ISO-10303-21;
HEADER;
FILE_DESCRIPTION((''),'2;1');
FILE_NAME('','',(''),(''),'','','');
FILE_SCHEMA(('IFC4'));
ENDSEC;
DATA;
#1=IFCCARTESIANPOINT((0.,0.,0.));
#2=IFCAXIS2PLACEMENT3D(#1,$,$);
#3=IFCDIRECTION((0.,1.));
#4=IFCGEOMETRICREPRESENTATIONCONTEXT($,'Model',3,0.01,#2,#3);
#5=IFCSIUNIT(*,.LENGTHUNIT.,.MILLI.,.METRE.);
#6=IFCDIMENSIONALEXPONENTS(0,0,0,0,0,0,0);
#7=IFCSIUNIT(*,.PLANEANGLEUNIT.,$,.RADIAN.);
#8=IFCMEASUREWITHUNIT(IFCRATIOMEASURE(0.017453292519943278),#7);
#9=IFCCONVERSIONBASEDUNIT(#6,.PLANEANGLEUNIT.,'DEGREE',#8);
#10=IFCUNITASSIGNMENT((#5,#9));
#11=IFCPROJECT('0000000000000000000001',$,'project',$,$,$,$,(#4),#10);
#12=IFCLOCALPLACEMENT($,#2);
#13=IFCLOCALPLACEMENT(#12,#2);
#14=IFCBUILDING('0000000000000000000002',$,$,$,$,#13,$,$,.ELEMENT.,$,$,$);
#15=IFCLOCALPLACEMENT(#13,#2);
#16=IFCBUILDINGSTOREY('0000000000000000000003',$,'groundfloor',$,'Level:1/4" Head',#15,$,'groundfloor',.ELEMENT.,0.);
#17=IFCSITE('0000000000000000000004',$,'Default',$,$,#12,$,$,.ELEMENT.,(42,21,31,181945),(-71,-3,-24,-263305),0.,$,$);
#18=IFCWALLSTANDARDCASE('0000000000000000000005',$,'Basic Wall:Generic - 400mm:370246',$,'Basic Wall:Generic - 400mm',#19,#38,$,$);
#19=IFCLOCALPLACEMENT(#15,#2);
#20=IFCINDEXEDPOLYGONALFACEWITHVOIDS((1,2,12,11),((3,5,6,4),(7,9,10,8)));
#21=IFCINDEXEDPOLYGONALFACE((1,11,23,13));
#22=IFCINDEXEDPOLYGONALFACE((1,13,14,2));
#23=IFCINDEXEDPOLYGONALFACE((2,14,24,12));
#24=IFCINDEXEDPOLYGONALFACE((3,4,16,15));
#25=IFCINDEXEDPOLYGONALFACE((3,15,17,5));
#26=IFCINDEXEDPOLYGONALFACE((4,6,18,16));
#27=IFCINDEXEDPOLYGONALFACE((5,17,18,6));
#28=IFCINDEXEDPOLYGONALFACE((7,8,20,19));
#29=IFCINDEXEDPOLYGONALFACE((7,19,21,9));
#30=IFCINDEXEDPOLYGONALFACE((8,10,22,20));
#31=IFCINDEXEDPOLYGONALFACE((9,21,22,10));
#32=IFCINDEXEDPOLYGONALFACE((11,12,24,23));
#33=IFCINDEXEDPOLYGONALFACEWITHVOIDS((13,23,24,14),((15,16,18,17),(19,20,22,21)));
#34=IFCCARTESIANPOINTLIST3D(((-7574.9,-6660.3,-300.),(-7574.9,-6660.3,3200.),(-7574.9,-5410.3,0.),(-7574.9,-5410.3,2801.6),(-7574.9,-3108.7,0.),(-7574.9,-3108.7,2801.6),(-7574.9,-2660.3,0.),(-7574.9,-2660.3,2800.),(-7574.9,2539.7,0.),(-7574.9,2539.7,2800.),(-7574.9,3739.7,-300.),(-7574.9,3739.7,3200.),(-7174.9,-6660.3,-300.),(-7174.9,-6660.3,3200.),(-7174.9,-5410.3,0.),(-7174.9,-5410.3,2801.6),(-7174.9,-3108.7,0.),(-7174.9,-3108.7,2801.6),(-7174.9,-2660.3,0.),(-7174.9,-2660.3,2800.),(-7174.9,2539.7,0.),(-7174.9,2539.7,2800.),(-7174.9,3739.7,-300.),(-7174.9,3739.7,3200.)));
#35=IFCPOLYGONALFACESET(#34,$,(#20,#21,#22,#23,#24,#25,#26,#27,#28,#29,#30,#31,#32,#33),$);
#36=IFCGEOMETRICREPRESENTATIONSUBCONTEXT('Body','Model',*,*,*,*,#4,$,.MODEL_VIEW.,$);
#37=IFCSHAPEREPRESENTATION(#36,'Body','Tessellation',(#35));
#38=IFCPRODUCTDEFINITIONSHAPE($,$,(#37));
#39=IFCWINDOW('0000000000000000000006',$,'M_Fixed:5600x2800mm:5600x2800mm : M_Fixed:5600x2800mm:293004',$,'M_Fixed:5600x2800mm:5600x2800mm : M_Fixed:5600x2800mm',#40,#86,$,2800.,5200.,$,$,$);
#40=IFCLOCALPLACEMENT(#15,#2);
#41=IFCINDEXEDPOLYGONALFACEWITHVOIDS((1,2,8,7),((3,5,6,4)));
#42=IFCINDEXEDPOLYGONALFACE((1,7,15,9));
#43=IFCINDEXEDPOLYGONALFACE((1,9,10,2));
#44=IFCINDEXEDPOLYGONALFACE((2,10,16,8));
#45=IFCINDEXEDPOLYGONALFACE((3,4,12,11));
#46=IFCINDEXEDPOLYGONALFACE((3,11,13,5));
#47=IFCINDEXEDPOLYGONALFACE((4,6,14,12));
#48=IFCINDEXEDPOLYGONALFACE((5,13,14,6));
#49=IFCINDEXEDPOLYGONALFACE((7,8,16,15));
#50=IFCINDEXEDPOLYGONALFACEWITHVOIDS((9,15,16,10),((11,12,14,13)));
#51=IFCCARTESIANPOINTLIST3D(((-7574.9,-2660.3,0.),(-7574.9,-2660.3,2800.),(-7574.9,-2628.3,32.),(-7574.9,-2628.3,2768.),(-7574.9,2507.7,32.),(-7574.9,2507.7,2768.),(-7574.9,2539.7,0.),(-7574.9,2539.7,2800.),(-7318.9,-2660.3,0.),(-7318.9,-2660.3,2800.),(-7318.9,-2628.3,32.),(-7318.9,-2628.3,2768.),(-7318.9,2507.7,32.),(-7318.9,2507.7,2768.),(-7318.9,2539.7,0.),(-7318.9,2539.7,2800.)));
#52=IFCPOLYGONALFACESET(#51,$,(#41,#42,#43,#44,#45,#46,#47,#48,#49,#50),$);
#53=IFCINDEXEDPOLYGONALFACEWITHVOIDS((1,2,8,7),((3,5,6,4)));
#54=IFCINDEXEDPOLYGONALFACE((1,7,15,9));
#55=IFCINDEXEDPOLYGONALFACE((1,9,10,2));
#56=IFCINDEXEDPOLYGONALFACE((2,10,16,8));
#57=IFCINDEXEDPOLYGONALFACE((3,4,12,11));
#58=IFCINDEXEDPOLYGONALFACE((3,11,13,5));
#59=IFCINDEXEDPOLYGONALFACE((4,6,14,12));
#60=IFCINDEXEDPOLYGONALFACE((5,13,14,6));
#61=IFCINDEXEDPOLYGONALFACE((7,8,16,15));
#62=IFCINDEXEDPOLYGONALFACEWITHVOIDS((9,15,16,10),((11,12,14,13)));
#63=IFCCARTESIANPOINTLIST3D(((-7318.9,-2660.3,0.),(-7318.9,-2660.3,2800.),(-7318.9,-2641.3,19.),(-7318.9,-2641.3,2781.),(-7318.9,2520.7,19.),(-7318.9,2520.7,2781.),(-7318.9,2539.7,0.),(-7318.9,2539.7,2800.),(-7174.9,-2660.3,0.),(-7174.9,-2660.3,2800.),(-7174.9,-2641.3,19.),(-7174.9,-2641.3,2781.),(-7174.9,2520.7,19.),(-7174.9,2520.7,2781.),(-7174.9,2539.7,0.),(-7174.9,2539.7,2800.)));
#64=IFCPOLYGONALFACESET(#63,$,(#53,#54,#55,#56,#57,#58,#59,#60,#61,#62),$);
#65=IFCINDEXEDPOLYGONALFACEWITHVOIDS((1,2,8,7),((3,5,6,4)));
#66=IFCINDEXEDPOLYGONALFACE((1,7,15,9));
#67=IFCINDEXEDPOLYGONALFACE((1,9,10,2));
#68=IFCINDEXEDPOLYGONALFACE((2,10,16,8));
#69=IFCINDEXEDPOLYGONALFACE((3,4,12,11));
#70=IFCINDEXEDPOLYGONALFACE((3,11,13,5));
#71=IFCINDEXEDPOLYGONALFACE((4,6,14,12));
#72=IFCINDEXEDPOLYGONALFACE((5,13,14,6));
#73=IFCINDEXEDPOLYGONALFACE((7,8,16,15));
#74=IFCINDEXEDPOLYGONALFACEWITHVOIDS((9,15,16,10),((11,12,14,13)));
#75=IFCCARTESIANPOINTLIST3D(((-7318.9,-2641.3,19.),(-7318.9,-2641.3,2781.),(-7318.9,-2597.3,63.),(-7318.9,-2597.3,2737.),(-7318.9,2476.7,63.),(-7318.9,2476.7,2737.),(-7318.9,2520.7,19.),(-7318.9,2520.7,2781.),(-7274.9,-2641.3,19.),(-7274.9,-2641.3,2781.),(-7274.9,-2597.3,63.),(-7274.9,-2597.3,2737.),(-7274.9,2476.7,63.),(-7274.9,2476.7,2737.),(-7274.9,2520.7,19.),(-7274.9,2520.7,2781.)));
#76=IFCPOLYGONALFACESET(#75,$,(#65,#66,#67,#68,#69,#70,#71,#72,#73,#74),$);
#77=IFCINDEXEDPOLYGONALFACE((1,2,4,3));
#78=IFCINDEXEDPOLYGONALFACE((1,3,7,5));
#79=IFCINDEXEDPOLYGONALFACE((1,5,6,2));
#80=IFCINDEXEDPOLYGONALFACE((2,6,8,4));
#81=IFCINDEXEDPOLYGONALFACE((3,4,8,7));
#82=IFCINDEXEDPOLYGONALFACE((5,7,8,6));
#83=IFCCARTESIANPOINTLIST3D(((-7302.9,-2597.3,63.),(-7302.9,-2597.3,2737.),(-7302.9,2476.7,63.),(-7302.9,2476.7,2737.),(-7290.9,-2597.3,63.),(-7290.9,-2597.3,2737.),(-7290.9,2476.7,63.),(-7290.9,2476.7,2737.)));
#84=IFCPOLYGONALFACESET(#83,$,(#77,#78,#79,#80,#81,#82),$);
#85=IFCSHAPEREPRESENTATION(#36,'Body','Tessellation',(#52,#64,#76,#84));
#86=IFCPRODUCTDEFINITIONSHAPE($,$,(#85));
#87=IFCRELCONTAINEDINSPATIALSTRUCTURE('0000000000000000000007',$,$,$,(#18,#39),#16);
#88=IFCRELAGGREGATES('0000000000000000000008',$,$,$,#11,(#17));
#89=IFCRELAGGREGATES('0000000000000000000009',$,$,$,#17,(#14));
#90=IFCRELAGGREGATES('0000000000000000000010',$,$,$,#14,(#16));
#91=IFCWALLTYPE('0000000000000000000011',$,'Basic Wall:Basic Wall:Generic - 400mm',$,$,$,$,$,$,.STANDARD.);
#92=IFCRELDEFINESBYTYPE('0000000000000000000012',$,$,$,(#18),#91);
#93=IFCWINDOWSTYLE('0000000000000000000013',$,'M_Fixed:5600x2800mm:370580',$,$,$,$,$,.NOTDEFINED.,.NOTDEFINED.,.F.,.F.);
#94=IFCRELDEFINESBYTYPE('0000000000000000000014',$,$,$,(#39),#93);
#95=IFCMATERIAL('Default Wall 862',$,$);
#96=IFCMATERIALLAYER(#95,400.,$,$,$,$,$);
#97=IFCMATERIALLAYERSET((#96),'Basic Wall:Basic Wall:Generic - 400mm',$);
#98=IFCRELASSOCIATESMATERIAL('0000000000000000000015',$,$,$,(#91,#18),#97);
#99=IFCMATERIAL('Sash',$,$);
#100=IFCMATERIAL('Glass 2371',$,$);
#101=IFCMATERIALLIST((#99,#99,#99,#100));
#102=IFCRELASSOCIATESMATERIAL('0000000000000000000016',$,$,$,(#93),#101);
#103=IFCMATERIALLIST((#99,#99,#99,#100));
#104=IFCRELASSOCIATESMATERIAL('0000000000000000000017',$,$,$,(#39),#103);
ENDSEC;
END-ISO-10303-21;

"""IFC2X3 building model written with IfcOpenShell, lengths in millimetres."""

from ifc_helpers import new_model, entity, si_unit, converted_unit, direction, frame, frame_2d, origin, origin_2d_with_axis, place, context, subcontext, project, spatial, polyline, rectangle, outline, extrude, source, transform, mapped, material, material_list, layer, layer_set, layer_usage, type_object, type_shapes, element, fill, save


model = new_model("IFC2X3")

# Units and contexts
model_context = context("Model", 3, precision=0.01, world=origin(), true_north=direction((0.0, 1.0)))
body_context = subcontext(model_context, "Body", "Model", "MODEL_VIEW")
ifc_project = project(units=[si_unit("LENGTHUNIT", "METRE", prefix="MILLI"), converted_unit("PLANEANGLEUNIT", "DEGREE", entity("IfcRatioMeasure", 0.017453292519943278), si_unit("PLANEANGLEUNIT", "RADIAN"), dimensions=[0, 0, 0, 0, 0, 0, 0])], contexts=[model_context])

# Site, building, storey
site_placement = place(None, origin())
site = spatial("IfcSite", under=ifc_project, at=site_placement, Name="Default", CompositionType="ELEMENT", RefLatitude=(42, 21, 31, 181945), RefLongitude=(-71, -3, -24, -263305), RefElevation=0.0)
building_placement = place(site_placement, origin())
building = spatial("IfcBuilding", under=site, at=building_placement, CompositionType="ELEMENT")
storey_placement = place(building_placement, origin())
storey = spatial("IfcBuildingStorey", under=building, at=storey_placement, Name="groundfloor", ObjectType="Level:1/4\" Head", LongName="groundfloor", CompositionType="ELEMENT", Elevation=0.0)

# Wall, openings, window
ifc_material_1 = material(Name="Default Wall 862")
ifc_layer_1 = layer(ifc_material_1, 400.0)
ifc_layer_set_1 = layer_set([ifc_layer_1], Name="Basic Wall:Basic Wall:Generic - 400mm")
wall_type_1 = type_object("IfcWallType", Name="Basic Wall:Basic Wall:Generic - 400mm", PredefinedType="STANDARD", material=ifc_layer_set_1)
ifc_material_2 = material(Name="Sash")
ifc_material_3 = material(Name="Glass 2371")
ifc_layer_usage_1 = layer_usage(ifc_layer_set_1, "AXIS2", "NEGATIVE", 200.0)
wall_1_placement = place(storey_placement, frame((-7374.9, 3739.7, -300.0), z_axis=(0.0, 0.0, 1.0), x_axis=(0.0, -1.0, 0.0)))
wall_1 = element("IfcWallStandardCase", 1, at=wall_1_placement, inside=storey, type_object=wall_type_1, material=ifc_layer_usage_1, Name="Basic Wall:Generic - 400mm:370246", ObjectType="Basic Wall:Generic - 400mm", context=body_context, shape_type="SweptSolid", body=[
    extrude(rectangle(XDim=10400.0, YDim=400.0, at=frame_2d((5200.0, 0.0), x_axis=(-1.0, 0.0))), origin(), (0.0, 0.0, 1.0), 3500.0),
])
opening_1_placement = place(wall_1_placement, origin())
element("IfcOpeningElement", 2, at=opening_1_placement, cuts=wall_1, ObjectType="Opening", context=body_context, shape_type="SweptSolid", body=[
    extrude(rectangle(XDim=2500.0, YDim=1000.0, at=origin_2d_with_axis()), frame((1700.0, -200.0, 4750.0), z_axis=(0.0, 1.0, 0.0), x_axis=(0.0, 0.0, -1.0)), (0.0, 0.0, 1.0), 400.0),
])
opening_2_placement = place(wall_1_placement, origin())
element("IfcOpeningElement", 3, at=opening_2_placement, cuts=wall_1, ObjectType="Opening", context=body_context, shape_type="SweptSolid", body=[
    extrude(rectangle(XDim=2500.0, YDim=1000.0, at=origin_2d_with_axis()), frame((3100.0, -200.0, 4750.0), z_axis=(0.0, 1.0, 0.0), x_axis=(0.0, 0.0, -1.0)), (0.0, 0.0, 1.0), 400.0),
])
opening_3_placement = place(wall_1_placement, origin())
element("IfcOpeningElement", 4, at=opening_3_placement, cuts=wall_1, ObjectType="Opening", context=body_context, shape_type="SweptSolid", body=[
    extrude(rectangle(XDim=2500.0, YDim=1000.0, at=origin_2d_with_axis()), frame((4500.0, -200.0, 4750.0), z_axis=(0.0, 1.0, 0.0), x_axis=(0.0, 0.0, -1.0)), (0.0, 0.0, 1.0), 400.0),
])
opening_4_placement = place(wall_1_placement, origin())
element("IfcOpeningElement", 5, at=opening_4_placement, cuts=wall_1, ObjectType="Opening", context=body_context, shape_type="SweptSolid", body=[
    extrude(rectangle(XDim=2500.0, YDim=1000.0, at=origin_2d_with_axis()), frame((5900.0, -200.0, 4750.0), z_axis=(0.0, 1.0, 0.0), x_axis=(0.0, 0.0, -1.0)), (0.0, 0.0, 1.0), 400.0),
])
opening_5_placement = place(wall_1_placement, origin())
element("IfcOpeningElement", 6, at=opening_5_placement, cuts=wall_1, ObjectType="Opening", context=body_context, shape_type="SweptSolid", body=[
    extrude(rectangle(XDim=2500.0, YDim=1000.0, at=origin_2d_with_axis()), frame((7300.0, -200.0, 4750.0), z_axis=(0.0, 1.0, 0.0), x_axis=(0.0, 0.0, -1.0)), (0.0, 0.0, 1.0), 400.0),
])
opening_6_placement = place(wall_1_placement, origin())
element("IfcOpeningElement", 7, at=opening_6_placement, cuts=wall_1, ObjectType="Opening", context=body_context, shape_type="SweptSolid", body=[
    extrude(rectangle(XDim=2500.0, YDim=1000.0, at=frame_2d((0.0, 0.0), x_axis=(1.0, 0.0))), frame((8700.0, -200.0, 4750.0), z_axis=(0.0, 1.0, 0.0), x_axis=(0.0, 0.0, -1.0)), (0.0, 0.0, 1.0), 400.0),
])
opening_7_placement = place(wall_1_placement, frame((3739.7, 7374.9, 300.0), z_axis=(0.0, 0.0, 1.0), x_axis=(0.0, 1.0, 0.0)))
opening_7 = element("IfcOpeningElement", 8, at=opening_7_placement, cuts=wall_1, ObjectType="Opening", context=body_context, shape_type="SweptSolid", body=[
    extrude(rectangle(XDim=2800.0, YDim=5200.0, at=frame_2d((0.0, 0.0), x_axis=(0.0, 1.0))), frame((-7578.9, -60.3, 1400.0), z_axis=(1.0, 0.0, 0.0), x_axis=(0.0, -1.0, 0.0)), (0.0, 0.0, 1.0), 408.0),
])
opening_8_placement = place(wall_1_placement, frame((3739.7, 7374.9, 300.0), z_axis=(0.0, 0.0, 1.0), x_axis=(0.0, 1.0, 0.0)))
element("IfcOpeningElement", 9, at=opening_8_placement, cuts=wall_1, ObjectType="Opening", context=body_context, shape_type="SweptSolid", body=[
    extrude(rectangle(XDim=2801.6, YDim=2301.6, at=frame_2d((0.0, 0.0), x_axis=(0.0, 1.0))), frame((-7578.9, -4259.5, 1400.8), z_axis=(1.0, 0.0, 0.0), x_axis=(0.0, -1.0, 0.0)), (0.0, 0.0, 1.0), 408.0),
])
ifc_material_list_1 = material_list([ifc_material_2, ifc_material_2, ifc_material_2, ifc_material_3])
ifc_material_list_2 = material_list([ifc_material_2, ifc_material_2, ifc_material_2, ifc_material_3])
window_style_1 = type_object("IfcWindowStyle", Name="M_Fixed:5600x2800mm:370580", ConstructionType="NOTDEFINED", OperationType="NOTDEFINED", ParameterTakesPrecedence=False, Sizeable=False, material=ifc_material_list_2)
shared_shape_1 = source(origin(), body_context, "Body", "SweptSolid", [
    extrude(outline(polyline([(-1400.0, -2600.0), (1400.0, -2600.0), (1400.0, 2600.0), (-1400.0, 2600.0), (-1400.0, -2600.0)]), holes=[polyline([(1368.0, 2568.0), (1368.0, -2568.0), (-1368.0, -2568.0), (-1368.0, 2568.0), (1368.0, 2568.0)])]), frame((2600.0, -404.0, 1400.0), z_axis=(0.0, 1.0, 0.0), x_axis=(0.0, 0.0, -1.0)), (0.0, 0.0, 1.0), 256.0),
    extrude(outline(polyline([(-1400.0, -2600.0), (1400.0, -2600.0), (1400.0, 2600.0), (-1400.0, 2600.0), (-1400.0, -2600.0)]), holes=[polyline([(1381.0, 2581.0), (1381.0, -2581.0), (-1381.0, -2581.0), (-1381.0, 2581.0), (1381.0, 2581.0)])]), frame((2600.0, -148.0, 1400.0), z_axis=(0.0, 1.0, 0.0), x_axis=(0.0, 0.0, -1.0)), (0.0, 0.0, 1.0), 144.0),
    extrude(outline(polyline([(-1381.0, -2581.0), (1381.0, -2581.0), (1381.0, 2581.0), (-1381.0, 2581.0), (-1381.0, -2581.0)]), holes=[polyline([(1337.0, 2537.0), (1337.0, -2537.0), (-1337.0, -2537.0), (-1337.0, 2537.0), (1337.0, 2537.0)])]), frame((2600.0, -148.0, 1400.0), z_axis=(0.0, 1.0, 0.0), x_axis=(0.0, 0.0, -1.0)), (0.0, 0.0, 1.0), 44.0),
    extrude(rectangle(XDim=5074.0, YDim=12.0, at=origin_2d_with_axis()), frame((2600.0, -126.0, 63.0)), (0.0, 0.0, 1.0), 2674.0),
])
type_shapes(window_style_1, [shared_shape_1])
window_1_placement = place(opening_7_placement, frame((-7170.9, 2539.7, 0.0), z_axis=(0.0, 0.0, 1.0), x_axis=(0.0, -1.0, 0.0)))
window_1 = element("IfcWindow", 10, at=window_1_placement, inside=storey, type_object=window_style_1, material=ifc_material_list_1, Name="M_Fixed:5600x2800mm:5600x2800mm : M_Fixed:5600x2800mm:293004", ObjectType="M_Fixed:5600x2800mm:5600x2800mm : M_Fixed:5600x2800mm", OverallHeight=2800.0, OverallWidth=5200.0, context=body_context, shape_type="MappedRepresentation", body=[
    mapped(shared_shape_1, transform((0.0, 0.0, 0.0), scale=1.0)),
])
fill(opening_7, window_1)

save(model, "model.ifc")
